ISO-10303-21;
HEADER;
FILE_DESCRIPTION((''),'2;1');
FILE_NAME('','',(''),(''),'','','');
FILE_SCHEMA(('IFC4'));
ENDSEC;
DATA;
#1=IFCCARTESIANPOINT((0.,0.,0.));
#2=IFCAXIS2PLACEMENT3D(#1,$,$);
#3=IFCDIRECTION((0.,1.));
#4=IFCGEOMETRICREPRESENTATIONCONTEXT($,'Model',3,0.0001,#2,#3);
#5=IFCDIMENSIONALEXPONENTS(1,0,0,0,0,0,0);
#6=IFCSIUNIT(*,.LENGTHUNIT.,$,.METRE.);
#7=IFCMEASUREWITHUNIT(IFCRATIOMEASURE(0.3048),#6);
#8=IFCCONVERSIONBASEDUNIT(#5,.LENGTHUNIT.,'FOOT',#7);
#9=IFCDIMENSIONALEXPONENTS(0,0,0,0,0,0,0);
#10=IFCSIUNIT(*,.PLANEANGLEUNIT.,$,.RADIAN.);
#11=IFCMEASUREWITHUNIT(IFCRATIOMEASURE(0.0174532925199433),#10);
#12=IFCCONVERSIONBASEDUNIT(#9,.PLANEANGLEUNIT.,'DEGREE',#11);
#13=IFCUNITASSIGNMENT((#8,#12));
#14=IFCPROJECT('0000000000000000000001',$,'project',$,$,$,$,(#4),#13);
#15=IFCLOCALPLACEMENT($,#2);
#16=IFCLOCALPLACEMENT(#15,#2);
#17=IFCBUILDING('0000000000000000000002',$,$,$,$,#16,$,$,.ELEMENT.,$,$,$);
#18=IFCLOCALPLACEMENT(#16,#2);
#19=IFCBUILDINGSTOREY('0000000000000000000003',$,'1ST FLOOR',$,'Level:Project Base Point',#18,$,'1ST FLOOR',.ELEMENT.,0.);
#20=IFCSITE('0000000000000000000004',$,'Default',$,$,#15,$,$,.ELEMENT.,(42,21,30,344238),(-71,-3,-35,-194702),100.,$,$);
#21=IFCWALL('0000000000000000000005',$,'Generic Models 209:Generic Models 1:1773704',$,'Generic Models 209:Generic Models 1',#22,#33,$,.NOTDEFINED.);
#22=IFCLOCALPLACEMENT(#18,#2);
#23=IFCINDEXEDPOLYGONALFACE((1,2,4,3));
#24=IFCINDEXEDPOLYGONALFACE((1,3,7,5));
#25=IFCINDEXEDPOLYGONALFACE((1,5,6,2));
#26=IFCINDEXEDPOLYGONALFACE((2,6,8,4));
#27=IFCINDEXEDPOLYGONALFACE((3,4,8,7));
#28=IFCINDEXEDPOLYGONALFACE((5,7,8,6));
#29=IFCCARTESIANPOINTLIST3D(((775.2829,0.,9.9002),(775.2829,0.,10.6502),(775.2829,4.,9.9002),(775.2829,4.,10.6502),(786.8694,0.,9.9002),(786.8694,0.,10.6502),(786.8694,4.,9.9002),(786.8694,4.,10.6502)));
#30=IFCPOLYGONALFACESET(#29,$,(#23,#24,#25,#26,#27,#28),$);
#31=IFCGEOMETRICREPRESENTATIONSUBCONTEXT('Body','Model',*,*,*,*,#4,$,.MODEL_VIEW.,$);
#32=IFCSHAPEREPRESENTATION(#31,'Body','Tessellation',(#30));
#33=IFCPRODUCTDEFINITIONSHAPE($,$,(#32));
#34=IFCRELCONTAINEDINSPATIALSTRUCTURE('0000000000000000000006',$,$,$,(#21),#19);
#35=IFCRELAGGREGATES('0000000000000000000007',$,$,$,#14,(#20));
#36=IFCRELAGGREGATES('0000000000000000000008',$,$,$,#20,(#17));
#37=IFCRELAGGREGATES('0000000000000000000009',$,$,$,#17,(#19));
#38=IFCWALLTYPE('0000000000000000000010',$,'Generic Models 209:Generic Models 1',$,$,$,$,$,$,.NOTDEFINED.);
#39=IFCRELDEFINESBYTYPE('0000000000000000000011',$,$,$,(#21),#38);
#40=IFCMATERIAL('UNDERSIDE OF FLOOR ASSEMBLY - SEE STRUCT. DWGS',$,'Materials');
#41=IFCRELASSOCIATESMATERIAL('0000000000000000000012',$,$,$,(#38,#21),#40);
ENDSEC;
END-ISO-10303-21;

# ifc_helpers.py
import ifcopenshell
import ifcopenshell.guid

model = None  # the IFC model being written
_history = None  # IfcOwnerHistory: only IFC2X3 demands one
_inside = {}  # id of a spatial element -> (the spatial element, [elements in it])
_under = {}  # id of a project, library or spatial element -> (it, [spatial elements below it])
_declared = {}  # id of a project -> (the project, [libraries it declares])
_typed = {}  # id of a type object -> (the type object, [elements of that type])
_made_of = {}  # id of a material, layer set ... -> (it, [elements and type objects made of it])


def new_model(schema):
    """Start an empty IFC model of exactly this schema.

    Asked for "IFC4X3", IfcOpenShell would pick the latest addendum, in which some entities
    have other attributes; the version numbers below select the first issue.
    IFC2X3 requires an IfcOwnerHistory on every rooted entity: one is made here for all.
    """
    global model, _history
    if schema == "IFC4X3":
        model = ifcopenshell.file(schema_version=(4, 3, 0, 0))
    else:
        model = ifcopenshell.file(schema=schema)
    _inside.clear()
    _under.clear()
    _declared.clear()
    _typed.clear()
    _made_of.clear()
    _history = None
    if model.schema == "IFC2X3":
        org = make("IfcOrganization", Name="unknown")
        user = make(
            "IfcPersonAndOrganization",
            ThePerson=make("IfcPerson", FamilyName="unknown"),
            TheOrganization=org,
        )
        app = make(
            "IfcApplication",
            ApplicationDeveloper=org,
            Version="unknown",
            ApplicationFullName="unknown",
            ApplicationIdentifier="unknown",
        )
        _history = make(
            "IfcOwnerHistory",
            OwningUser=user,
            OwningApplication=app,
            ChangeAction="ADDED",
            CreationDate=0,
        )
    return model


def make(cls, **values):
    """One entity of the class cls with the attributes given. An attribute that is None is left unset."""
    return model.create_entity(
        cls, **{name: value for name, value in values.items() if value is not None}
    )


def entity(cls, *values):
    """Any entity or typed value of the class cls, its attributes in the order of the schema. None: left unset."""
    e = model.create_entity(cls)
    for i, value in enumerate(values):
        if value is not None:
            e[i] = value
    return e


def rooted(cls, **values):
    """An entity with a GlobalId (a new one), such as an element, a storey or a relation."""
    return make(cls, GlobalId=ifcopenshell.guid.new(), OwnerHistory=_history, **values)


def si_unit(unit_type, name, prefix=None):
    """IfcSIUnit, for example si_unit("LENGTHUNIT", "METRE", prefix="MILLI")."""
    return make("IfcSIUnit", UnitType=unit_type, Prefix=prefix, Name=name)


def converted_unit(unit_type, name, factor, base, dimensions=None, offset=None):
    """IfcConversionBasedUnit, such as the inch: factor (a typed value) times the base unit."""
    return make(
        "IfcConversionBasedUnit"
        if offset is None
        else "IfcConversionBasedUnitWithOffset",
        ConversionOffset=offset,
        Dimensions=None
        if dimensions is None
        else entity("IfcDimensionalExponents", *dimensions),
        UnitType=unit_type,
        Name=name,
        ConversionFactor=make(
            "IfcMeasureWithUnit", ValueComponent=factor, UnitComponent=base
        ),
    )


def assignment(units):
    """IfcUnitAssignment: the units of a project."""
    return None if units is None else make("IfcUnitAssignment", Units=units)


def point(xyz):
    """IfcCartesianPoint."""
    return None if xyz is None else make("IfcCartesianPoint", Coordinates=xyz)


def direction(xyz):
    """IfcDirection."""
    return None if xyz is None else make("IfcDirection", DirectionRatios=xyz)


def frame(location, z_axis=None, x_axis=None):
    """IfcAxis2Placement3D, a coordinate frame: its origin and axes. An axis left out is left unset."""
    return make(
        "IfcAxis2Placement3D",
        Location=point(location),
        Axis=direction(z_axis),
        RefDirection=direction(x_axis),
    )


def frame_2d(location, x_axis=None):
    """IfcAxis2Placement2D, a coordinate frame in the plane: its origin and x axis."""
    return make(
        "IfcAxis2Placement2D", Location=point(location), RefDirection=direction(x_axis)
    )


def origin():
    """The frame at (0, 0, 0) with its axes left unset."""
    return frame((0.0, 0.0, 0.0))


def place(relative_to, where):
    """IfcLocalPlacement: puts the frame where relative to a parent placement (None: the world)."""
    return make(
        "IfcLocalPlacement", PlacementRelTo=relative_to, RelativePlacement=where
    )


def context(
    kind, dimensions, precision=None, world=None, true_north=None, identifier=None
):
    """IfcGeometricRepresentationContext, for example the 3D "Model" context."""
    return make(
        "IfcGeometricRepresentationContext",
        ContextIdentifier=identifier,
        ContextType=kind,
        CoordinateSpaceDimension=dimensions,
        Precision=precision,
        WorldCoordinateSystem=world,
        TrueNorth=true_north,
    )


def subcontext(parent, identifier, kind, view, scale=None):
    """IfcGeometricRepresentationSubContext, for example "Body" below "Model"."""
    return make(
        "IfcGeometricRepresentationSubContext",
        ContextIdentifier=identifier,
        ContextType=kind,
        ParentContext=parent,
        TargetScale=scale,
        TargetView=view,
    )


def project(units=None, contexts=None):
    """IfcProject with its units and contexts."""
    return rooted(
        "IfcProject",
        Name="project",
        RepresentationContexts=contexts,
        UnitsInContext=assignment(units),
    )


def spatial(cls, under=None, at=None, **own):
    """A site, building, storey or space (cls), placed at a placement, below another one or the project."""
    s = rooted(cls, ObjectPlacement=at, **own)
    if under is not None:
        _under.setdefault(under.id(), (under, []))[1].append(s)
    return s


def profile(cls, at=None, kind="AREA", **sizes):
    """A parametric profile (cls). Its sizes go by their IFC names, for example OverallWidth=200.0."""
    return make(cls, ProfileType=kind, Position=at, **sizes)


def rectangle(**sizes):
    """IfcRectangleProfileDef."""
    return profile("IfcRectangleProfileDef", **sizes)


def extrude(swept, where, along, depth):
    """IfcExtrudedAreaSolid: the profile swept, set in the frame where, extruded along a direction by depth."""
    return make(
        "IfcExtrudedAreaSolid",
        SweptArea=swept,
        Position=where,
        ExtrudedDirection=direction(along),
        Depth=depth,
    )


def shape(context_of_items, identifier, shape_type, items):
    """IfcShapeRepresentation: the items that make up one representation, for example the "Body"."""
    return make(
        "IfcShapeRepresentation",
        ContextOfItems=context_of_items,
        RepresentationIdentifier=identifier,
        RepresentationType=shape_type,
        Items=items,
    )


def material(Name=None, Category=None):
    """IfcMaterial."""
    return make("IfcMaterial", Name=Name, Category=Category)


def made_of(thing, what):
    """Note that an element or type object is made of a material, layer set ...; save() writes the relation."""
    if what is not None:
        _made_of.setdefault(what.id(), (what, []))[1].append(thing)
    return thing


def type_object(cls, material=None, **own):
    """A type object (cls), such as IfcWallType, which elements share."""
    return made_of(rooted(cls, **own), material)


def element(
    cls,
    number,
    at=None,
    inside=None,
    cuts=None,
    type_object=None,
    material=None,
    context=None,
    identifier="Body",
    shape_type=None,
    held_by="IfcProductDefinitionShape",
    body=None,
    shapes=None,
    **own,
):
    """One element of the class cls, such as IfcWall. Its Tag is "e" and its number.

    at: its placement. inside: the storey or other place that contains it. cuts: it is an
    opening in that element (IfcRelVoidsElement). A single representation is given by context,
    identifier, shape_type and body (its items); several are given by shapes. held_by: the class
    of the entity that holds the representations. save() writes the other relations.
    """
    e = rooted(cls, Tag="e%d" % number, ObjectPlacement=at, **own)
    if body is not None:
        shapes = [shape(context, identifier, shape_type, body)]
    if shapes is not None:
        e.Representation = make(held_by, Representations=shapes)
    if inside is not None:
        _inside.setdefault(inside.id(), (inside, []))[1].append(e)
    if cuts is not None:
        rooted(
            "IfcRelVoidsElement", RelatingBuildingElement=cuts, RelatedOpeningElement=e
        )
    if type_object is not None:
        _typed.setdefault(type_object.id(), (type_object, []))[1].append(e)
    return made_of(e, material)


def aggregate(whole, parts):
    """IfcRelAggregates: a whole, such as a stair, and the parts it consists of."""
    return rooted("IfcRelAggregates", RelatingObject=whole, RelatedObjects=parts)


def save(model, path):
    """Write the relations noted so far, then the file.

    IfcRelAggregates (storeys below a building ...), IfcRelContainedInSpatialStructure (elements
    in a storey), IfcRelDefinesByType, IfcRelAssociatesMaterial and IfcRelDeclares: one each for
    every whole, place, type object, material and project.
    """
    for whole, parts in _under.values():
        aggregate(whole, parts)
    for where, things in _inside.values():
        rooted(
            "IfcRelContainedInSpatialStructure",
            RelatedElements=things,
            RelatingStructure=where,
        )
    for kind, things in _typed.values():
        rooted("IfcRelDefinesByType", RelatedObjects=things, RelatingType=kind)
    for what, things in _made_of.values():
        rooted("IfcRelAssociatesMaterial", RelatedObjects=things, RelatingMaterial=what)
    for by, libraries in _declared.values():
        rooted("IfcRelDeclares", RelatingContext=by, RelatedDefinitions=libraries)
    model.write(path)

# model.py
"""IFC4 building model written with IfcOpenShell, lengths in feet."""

from ifc_helpers import new_model, entity, si_unit, converted_unit, direction, frame, frame_2d, origin, place, context, subcontext, project, spatial, rectangle, extrude, material, type_object, element, save


model = new_model("IFC4")

# Units and contexts
model_context = context("Model", 3, precision=0.0001, world=origin(), true_north=direction((0.0, 1.0)))
body_context = subcontext(model_context, "Body", "Model", "MODEL_VIEW")
ifc_project = project(units=[converted_unit("LENGTHUNIT", "FOOT", entity("IfcRatioMeasure", 0.3048), si_unit("LENGTHUNIT", "METRE"), dimensions=[1, 0, 0, 0, 0, 0, 0]), converted_unit("PLANEANGLEUNIT", "DEGREE", entity("IfcRatioMeasure", 0.0174532925199433), si_unit("PLANEANGLEUNIT", "RADIAN"), dimensions=[0, 0, 0, 0, 0, 0, 0])], contexts=[model_context])

# Site, building, storey
site_placement = place(None, origin())
site = spatial("IfcSite", under=ifc_project, at=site_placement, Name="Default", CompositionType="ELEMENT", RefLatitude=(42, 21, 30, 344238), RefLongitude=(-71, -3, -35, -194702), RefElevation=100.0)
building_placement = place(site_placement, origin())
building = spatial("IfcBuilding", under=site, at=building_placement, CompositionType="ELEMENT")
storey_placement = place(building_placement, origin())
storey = spatial("IfcBuildingStorey", under=building, at=storey_placement, Name="1ST FLOOR", ObjectType="Level:Project Base Point", LongName="1ST FLOOR", CompositionType="ELEMENT", Elevation=0.0)

# Wall
ifc_material_1 = material(Name="UNDERSIDE OF FLOOR ASSEMBLY - SEE STRUCT. DWGS", Category="Materials")
wall_type = type_object("IfcWallType", Name="Generic Models 209:Generic Models 1", PredefinedType="NOTDEFINED", material=ifc_material_1)
wall_placement = place(storey_placement, frame((775.2829, 0.0, 9.9002)))
element("IfcWall", 1, at=wall_placement, inside=storey, type_object=wall_type, material=ifc_material_1, Name="Generic Models 209:Generic Models 1:1773704", ObjectType="Generic Models 209:Generic Models 1", PredefinedType="NOTDEFINED", context=body_context, shape_type="SweptSolid", body=[
    extrude(rectangle(XDim=4.0, YDim=11.5865, at=frame_2d((0.0, 0.0), x_axis=(1.0, 0.0))), frame((5.7933, 2.0, 0.0), z_axis=(0.0, 0.0, 1.0), x_axis=(0.0, 1.0, 0.0)), (0.0, 0.0, 1.0), 0.75),
])

save(model, "model.ifc")
